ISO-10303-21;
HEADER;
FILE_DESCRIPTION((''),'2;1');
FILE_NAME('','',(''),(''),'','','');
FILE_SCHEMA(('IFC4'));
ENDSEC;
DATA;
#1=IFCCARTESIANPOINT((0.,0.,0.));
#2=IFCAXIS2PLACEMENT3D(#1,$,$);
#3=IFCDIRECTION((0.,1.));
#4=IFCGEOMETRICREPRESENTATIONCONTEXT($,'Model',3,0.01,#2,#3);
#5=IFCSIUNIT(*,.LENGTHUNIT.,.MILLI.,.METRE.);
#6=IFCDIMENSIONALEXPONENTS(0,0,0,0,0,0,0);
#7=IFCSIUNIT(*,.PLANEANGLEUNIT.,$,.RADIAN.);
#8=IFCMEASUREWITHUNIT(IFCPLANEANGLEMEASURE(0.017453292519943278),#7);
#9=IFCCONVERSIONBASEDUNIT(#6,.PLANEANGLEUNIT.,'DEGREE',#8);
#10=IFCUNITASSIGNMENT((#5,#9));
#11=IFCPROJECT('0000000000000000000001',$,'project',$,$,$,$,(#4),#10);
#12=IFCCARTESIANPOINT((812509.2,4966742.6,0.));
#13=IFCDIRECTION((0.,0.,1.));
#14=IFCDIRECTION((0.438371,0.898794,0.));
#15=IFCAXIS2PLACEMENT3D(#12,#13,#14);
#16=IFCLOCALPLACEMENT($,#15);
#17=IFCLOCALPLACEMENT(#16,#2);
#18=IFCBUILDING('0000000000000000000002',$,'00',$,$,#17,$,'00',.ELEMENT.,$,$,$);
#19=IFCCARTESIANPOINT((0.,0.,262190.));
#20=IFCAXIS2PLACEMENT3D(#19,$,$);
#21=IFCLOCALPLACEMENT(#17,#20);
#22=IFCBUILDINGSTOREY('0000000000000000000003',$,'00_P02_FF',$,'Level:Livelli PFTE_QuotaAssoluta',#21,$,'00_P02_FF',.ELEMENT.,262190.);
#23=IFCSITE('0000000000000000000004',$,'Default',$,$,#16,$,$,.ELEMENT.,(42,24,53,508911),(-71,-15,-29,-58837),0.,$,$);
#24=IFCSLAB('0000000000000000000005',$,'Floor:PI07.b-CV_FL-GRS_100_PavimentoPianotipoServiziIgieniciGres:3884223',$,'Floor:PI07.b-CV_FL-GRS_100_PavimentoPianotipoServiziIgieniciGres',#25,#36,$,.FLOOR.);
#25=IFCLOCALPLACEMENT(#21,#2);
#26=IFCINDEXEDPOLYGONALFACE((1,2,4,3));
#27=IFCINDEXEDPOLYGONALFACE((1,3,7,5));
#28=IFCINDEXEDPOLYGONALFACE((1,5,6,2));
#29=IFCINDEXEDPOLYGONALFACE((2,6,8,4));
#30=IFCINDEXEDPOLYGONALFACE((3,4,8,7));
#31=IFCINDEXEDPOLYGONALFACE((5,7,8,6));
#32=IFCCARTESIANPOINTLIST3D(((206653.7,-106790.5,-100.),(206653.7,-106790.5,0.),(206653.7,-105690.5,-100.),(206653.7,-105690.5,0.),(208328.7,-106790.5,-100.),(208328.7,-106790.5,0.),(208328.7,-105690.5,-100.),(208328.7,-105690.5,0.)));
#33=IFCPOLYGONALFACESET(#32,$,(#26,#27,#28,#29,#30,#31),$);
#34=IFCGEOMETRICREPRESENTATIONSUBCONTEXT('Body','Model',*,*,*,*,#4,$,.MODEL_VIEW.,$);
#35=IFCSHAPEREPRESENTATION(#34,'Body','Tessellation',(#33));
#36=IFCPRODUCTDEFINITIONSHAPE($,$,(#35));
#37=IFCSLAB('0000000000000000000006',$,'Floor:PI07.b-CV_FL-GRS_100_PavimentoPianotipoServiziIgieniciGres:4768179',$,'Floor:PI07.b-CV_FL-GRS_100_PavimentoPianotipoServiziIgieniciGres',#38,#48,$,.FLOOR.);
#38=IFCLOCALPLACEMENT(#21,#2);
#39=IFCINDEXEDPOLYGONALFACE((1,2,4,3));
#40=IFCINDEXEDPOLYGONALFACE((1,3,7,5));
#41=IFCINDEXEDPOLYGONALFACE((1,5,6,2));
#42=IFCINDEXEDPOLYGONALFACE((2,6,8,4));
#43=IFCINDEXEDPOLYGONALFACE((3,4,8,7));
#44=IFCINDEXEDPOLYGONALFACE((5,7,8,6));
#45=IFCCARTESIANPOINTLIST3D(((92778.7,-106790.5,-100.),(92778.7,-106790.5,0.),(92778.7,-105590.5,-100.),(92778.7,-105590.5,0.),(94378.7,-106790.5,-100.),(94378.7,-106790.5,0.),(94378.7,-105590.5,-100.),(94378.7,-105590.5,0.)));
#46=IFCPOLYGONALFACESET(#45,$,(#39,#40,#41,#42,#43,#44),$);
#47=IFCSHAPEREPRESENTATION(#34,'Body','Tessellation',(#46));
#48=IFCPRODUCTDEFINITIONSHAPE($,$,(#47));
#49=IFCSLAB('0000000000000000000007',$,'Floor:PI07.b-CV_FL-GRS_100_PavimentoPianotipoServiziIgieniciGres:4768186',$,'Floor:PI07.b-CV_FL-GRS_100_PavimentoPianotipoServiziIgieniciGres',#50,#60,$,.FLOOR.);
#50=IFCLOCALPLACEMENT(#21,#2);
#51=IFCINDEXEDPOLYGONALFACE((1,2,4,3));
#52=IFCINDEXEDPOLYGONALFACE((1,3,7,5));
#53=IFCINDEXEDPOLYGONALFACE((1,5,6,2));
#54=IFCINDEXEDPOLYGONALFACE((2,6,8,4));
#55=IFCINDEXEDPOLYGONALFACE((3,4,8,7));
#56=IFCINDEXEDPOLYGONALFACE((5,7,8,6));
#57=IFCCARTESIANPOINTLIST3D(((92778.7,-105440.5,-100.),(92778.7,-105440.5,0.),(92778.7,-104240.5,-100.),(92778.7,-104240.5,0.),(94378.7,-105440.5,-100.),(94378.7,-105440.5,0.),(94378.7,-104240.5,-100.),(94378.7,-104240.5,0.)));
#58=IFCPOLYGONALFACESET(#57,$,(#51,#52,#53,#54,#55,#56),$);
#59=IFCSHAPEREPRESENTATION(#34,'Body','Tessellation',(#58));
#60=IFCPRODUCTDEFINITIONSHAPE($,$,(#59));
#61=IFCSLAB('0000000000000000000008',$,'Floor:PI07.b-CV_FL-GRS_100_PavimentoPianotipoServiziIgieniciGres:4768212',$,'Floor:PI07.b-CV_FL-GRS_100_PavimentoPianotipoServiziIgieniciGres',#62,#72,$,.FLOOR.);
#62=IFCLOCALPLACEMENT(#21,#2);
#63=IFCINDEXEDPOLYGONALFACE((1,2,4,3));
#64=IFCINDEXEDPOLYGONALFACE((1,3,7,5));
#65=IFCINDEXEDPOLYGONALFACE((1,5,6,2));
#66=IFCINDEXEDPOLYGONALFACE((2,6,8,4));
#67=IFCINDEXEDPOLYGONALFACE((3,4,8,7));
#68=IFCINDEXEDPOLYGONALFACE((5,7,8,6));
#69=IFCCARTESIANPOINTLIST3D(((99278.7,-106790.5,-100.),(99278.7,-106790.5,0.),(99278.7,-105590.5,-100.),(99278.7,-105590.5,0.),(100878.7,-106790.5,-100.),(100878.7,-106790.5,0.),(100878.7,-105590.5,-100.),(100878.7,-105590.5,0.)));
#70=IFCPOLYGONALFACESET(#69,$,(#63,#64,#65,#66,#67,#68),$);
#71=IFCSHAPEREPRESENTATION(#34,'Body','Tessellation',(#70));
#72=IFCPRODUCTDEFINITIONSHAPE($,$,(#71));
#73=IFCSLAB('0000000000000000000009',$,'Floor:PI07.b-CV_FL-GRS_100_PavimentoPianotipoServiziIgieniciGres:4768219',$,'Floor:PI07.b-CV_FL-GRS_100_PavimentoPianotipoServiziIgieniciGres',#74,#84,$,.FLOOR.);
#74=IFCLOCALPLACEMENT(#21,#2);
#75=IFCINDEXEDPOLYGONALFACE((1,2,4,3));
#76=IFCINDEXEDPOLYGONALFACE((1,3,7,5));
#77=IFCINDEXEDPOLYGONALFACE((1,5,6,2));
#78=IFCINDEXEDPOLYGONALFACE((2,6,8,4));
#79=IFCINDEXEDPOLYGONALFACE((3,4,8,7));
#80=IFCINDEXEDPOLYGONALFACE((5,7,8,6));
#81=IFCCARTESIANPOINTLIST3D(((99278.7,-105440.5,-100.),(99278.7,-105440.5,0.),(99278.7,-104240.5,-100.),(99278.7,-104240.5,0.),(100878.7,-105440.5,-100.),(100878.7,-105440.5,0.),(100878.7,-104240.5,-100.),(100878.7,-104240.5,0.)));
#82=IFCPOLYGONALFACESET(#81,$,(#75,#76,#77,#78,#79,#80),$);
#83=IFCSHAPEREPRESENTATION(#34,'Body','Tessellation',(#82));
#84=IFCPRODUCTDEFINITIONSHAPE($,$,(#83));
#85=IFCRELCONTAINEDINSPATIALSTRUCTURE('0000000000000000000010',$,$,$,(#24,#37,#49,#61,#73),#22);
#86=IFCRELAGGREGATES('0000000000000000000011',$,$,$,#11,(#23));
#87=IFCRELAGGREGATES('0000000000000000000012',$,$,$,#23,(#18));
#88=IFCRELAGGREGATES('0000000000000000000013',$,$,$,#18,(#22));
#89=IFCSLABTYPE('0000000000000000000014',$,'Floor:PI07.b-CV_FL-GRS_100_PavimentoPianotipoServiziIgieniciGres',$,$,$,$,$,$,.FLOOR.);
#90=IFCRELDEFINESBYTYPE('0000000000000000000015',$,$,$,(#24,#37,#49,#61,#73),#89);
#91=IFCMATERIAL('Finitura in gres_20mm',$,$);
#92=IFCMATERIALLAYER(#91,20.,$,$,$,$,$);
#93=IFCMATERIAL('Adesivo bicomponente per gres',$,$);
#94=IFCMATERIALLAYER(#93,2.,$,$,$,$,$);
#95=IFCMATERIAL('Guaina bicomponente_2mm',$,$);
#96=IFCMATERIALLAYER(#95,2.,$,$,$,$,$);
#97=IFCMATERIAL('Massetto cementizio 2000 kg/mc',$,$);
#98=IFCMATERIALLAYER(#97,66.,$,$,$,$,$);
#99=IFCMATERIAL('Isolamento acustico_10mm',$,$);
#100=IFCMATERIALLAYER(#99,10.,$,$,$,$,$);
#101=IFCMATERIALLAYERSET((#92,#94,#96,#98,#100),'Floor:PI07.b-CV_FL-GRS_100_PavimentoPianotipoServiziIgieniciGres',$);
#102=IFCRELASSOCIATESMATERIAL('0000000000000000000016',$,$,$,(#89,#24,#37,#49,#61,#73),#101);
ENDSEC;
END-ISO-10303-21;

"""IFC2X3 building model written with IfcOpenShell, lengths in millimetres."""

from ifc_helpers import new_model, entity, si_unit, converted_unit, direction, frame, frame_2d, origin, origin_2d_with_axis, place, context, subcontext, project, spatial, rectangle, extrude, material, layer, layer_set, layer_usage, type_object, element, save


model = new_model("IFC2X3")

# Units and contexts
model_context = context("Model", 3, precision=0.01, world=origin(), true_north=direction((0.0, 1.0)))
body_context = subcontext(model_context, "Body", "Model", "MODEL_VIEW")
ifc_project = project(units=[si_unit("LENGTHUNIT", "METRE", prefix="MILLI"), converted_unit("PLANEANGLEUNIT", "DEGREE", entity("IfcPlaneAngleMeasure", 0.017453292519943278), si_unit("PLANEANGLEUNIT", "RADIAN"), dimensions=[0, 0, 0, 0, 0, 0, 0])], contexts=[model_context])

# Site, building, storey
site_placement = place(None, frame((812509.2, 4966742.6, 0.0), z_axis=(0.0, 0.0, 1.0), x_axis=(0.438371, 0.898794, 0.0)))
site = spatial("IfcSite", under=ifc_project, at=site_placement, Name="Default", CompositionType="ELEMENT", RefLatitude=(42, 24, 53, 508911), RefLongitude=(-71, -15, -29, -58837), RefElevation=0.0)
building_placement = place(site_placement, origin())
building = spatial("IfcBuilding", under=site, at=building_placement, Name="00", LongName="00", CompositionType="ELEMENT")
storey_placement = place(building_placement, frame((0.0, 0.0, 262190.0)))
storey = spatial("IfcBuildingStorey", under=building, at=storey_placement, Name="00_P02_FF", ObjectType="Level:Livelli PFTE_QuotaAssoluta", LongName="00_P02_FF", CompositionType="ELEMENT", Elevation=262190.0)

# Slabs
ifc_material_1 = material(Name="Massetto cementizio 2000 kg/mc")
ifc_material_2 = material(Name="Isolamento acustico_10mm")
ifc_material_3 = material(Name="Finitura in gres_20mm")
ifc_layer_1 = layer(ifc_material_3, 20.0)
ifc_material_4 = material(Name="Adesivo bicomponente per gres")
ifc_layer_2 = layer(ifc_material_4, 2.0)
ifc_material_5 = material(Name="Guaina bicomponente_2mm")
ifc_layer_3 = layer(ifc_material_5, 2.0)
ifc_layer_4 = layer(ifc_material_1, 66.0)
ifc_layer_5 = layer(ifc_material_2, 10.0)
ifc_layer_set_1 = layer_set([ifc_layer_1, ifc_layer_2, ifc_layer_3, ifc_layer_4, ifc_layer_5], Name="Floor:PI07.b-CV_FL-GRS_100_PavimentoPianotipoServiziIgieniciGres")
ifc_layer_usage_1 = layer_usage(ifc_layer_set_1, "AXIS3", "POSITIVE", 0.0)
slab_type_1 = type_object("IfcSlabType", Name="Floor:PI07.b-CV_FL-GRS_100_PavimentoPianotipoServiziIgieniciGres", PredefinedType="FLOOR", material=ifc_layer_set_1)
slab_1_placement = place(storey_placement, origin())
element("IfcSlab", 1, at=slab_1_placement, inside=storey, type_object=slab_type_1, material=ifc_layer_usage_1, Name="Floor:PI07.b-CV_FL-GRS_100_PavimentoPianotipoServiziIgieniciGres:3884223", ObjectType="Floor:PI07.b-CV_FL-GRS_100_PavimentoPianotipoServiziIgieniciGres", PredefinedType="FLOOR", context=body_context, shape_type="SweptSolid", body=[
    extrude(rectangle(XDim=1100.0, YDim=1675.0, at=frame_2d((0.0, 0.0), x_axis=(1.0, 0.0))), frame((207491.2, -106240.5, 0.0), z_axis=(0.0, 0.0, -1.0), x_axis=(0.0, 1.0, 0.0)), (0.0, 0.0, 1.0), 100.0),
])
ifc_layer_usage_2 = layer_usage(ifc_layer_set_1, "AXIS3", "POSITIVE", 0.0)
slab_2_placement = place(storey_placement, origin())
element("IfcSlab", 2, at=slab_2_placement, inside=storey, type_object=slab_type_1, material=ifc_layer_usage_2, Name="Floor:PI07.b-CV_FL-GRS_100_PavimentoPianotipoServiziIgieniciGres:4768179", ObjectType="Floor:PI07.b-CV_FL-GRS_100_PavimentoPianotipoServiziIgieniciGres", PredefinedType="FLOOR", context=body_context, shape_type="SweptSolid", body=[
    extrude(rectangle(XDim=1200.0, YDim=1600.0, at=origin_2d_with_axis()), frame((93578.7, -106190.5, 0.0), z_axis=(0.0, 0.0, -1.0), x_axis=(0.0, 1.0, 0.0)), (0.0, 0.0, 1.0), 100.0),
])
ifc_layer_usage_3 = layer_usage(ifc_layer_set_1, "AXIS3", "POSITIVE", 0.0)
slab_3_placement = place(storey_placement, origin())
element("IfcSlab", 3, at=slab_3_placement, inside=storey, type_object=slab_type_1, material=ifc_layer_usage_3, Name="Floor:PI07.b-CV_FL-GRS_100_PavimentoPianotipoServiziIgieniciGres:4768186", ObjectType="Floor:PI07.b-CV_FL-GRS_100_PavimentoPianotipoServiziIgieniciGres", PredefinedType="FLOOR", context=body_context, shape_type="SweptSolid", body=[
    extrude(rectangle(XDim=1200.0, YDim=1600.0, at=origin_2d_with_axis()), frame((93578.7, -104840.5, 0.0), z_axis=(0.0, 0.0, -1.0), x_axis=(0.0, 1.0, 0.0)), (0.0, 0.0, 1.0), 100.0),
])
ifc_layer_usage_4 = layer_usage(ifc_layer_set_1, "AXIS3", "POSITIVE", 0.0)
slab_4_placement = place(storey_placement, origin())
element("IfcSlab", 4, at=slab_4_placement, inside=storey, type_object=slab_type_1, material=ifc_layer_usage_4, Name="Floor:PI07.b-CV_FL-GRS_100_PavimentoPianotipoServiziIgieniciGres:4768212", ObjectType="Floor:PI07.b-CV_FL-GRS_100_PavimentoPianotipoServiziIgieniciGres", PredefinedType="FLOOR", context=body_context, shape_type="SweptSolid", body=[
    extrude(rectangle(XDim=1200.0, YDim=1600.0, at=frame_2d((0.0, 0.0), x_axis=(1.0, 0.0))), frame((100078.7, -106190.5, 0.0), z_axis=(0.0, 0.0, -1.0), x_axis=(0.0, 1.0, 0.0)), (0.0, 0.0, 1.0), 100.0),
])
ifc_layer_usage_5 = layer_usage(ifc_layer_set_1, "AXIS3", "POSITIVE", 0.0)
slab_5_placement = place(storey_placement, origin())
element("IfcSlab", 5, at=slab_5_placement, inside=storey, type_object=slab_type_1, material=ifc_layer_usage_5, Name="Floor:PI07.b-CV_FL-GRS_100_PavimentoPianotipoServiziIgieniciGres:4768219", ObjectType="Floor:PI07.b-CV_FL-GRS_100_PavimentoPianotipoServiziIgieniciGres", PredefinedType="FLOOR", context=body_context, shape_type="SweptSolid", body=[
    extrude(rectangle(XDim=1200.0, YDim=1600.0, at=origin_2d_with_axis()), frame((100078.7, -104840.5, 0.0), z_axis=(0.0, 0.0, -1.0), x_axis=(0.0, 1.0, 0.0)), (0.0, 0.0, 1.0), 100.0),
])

save(model, "model.ifc")
